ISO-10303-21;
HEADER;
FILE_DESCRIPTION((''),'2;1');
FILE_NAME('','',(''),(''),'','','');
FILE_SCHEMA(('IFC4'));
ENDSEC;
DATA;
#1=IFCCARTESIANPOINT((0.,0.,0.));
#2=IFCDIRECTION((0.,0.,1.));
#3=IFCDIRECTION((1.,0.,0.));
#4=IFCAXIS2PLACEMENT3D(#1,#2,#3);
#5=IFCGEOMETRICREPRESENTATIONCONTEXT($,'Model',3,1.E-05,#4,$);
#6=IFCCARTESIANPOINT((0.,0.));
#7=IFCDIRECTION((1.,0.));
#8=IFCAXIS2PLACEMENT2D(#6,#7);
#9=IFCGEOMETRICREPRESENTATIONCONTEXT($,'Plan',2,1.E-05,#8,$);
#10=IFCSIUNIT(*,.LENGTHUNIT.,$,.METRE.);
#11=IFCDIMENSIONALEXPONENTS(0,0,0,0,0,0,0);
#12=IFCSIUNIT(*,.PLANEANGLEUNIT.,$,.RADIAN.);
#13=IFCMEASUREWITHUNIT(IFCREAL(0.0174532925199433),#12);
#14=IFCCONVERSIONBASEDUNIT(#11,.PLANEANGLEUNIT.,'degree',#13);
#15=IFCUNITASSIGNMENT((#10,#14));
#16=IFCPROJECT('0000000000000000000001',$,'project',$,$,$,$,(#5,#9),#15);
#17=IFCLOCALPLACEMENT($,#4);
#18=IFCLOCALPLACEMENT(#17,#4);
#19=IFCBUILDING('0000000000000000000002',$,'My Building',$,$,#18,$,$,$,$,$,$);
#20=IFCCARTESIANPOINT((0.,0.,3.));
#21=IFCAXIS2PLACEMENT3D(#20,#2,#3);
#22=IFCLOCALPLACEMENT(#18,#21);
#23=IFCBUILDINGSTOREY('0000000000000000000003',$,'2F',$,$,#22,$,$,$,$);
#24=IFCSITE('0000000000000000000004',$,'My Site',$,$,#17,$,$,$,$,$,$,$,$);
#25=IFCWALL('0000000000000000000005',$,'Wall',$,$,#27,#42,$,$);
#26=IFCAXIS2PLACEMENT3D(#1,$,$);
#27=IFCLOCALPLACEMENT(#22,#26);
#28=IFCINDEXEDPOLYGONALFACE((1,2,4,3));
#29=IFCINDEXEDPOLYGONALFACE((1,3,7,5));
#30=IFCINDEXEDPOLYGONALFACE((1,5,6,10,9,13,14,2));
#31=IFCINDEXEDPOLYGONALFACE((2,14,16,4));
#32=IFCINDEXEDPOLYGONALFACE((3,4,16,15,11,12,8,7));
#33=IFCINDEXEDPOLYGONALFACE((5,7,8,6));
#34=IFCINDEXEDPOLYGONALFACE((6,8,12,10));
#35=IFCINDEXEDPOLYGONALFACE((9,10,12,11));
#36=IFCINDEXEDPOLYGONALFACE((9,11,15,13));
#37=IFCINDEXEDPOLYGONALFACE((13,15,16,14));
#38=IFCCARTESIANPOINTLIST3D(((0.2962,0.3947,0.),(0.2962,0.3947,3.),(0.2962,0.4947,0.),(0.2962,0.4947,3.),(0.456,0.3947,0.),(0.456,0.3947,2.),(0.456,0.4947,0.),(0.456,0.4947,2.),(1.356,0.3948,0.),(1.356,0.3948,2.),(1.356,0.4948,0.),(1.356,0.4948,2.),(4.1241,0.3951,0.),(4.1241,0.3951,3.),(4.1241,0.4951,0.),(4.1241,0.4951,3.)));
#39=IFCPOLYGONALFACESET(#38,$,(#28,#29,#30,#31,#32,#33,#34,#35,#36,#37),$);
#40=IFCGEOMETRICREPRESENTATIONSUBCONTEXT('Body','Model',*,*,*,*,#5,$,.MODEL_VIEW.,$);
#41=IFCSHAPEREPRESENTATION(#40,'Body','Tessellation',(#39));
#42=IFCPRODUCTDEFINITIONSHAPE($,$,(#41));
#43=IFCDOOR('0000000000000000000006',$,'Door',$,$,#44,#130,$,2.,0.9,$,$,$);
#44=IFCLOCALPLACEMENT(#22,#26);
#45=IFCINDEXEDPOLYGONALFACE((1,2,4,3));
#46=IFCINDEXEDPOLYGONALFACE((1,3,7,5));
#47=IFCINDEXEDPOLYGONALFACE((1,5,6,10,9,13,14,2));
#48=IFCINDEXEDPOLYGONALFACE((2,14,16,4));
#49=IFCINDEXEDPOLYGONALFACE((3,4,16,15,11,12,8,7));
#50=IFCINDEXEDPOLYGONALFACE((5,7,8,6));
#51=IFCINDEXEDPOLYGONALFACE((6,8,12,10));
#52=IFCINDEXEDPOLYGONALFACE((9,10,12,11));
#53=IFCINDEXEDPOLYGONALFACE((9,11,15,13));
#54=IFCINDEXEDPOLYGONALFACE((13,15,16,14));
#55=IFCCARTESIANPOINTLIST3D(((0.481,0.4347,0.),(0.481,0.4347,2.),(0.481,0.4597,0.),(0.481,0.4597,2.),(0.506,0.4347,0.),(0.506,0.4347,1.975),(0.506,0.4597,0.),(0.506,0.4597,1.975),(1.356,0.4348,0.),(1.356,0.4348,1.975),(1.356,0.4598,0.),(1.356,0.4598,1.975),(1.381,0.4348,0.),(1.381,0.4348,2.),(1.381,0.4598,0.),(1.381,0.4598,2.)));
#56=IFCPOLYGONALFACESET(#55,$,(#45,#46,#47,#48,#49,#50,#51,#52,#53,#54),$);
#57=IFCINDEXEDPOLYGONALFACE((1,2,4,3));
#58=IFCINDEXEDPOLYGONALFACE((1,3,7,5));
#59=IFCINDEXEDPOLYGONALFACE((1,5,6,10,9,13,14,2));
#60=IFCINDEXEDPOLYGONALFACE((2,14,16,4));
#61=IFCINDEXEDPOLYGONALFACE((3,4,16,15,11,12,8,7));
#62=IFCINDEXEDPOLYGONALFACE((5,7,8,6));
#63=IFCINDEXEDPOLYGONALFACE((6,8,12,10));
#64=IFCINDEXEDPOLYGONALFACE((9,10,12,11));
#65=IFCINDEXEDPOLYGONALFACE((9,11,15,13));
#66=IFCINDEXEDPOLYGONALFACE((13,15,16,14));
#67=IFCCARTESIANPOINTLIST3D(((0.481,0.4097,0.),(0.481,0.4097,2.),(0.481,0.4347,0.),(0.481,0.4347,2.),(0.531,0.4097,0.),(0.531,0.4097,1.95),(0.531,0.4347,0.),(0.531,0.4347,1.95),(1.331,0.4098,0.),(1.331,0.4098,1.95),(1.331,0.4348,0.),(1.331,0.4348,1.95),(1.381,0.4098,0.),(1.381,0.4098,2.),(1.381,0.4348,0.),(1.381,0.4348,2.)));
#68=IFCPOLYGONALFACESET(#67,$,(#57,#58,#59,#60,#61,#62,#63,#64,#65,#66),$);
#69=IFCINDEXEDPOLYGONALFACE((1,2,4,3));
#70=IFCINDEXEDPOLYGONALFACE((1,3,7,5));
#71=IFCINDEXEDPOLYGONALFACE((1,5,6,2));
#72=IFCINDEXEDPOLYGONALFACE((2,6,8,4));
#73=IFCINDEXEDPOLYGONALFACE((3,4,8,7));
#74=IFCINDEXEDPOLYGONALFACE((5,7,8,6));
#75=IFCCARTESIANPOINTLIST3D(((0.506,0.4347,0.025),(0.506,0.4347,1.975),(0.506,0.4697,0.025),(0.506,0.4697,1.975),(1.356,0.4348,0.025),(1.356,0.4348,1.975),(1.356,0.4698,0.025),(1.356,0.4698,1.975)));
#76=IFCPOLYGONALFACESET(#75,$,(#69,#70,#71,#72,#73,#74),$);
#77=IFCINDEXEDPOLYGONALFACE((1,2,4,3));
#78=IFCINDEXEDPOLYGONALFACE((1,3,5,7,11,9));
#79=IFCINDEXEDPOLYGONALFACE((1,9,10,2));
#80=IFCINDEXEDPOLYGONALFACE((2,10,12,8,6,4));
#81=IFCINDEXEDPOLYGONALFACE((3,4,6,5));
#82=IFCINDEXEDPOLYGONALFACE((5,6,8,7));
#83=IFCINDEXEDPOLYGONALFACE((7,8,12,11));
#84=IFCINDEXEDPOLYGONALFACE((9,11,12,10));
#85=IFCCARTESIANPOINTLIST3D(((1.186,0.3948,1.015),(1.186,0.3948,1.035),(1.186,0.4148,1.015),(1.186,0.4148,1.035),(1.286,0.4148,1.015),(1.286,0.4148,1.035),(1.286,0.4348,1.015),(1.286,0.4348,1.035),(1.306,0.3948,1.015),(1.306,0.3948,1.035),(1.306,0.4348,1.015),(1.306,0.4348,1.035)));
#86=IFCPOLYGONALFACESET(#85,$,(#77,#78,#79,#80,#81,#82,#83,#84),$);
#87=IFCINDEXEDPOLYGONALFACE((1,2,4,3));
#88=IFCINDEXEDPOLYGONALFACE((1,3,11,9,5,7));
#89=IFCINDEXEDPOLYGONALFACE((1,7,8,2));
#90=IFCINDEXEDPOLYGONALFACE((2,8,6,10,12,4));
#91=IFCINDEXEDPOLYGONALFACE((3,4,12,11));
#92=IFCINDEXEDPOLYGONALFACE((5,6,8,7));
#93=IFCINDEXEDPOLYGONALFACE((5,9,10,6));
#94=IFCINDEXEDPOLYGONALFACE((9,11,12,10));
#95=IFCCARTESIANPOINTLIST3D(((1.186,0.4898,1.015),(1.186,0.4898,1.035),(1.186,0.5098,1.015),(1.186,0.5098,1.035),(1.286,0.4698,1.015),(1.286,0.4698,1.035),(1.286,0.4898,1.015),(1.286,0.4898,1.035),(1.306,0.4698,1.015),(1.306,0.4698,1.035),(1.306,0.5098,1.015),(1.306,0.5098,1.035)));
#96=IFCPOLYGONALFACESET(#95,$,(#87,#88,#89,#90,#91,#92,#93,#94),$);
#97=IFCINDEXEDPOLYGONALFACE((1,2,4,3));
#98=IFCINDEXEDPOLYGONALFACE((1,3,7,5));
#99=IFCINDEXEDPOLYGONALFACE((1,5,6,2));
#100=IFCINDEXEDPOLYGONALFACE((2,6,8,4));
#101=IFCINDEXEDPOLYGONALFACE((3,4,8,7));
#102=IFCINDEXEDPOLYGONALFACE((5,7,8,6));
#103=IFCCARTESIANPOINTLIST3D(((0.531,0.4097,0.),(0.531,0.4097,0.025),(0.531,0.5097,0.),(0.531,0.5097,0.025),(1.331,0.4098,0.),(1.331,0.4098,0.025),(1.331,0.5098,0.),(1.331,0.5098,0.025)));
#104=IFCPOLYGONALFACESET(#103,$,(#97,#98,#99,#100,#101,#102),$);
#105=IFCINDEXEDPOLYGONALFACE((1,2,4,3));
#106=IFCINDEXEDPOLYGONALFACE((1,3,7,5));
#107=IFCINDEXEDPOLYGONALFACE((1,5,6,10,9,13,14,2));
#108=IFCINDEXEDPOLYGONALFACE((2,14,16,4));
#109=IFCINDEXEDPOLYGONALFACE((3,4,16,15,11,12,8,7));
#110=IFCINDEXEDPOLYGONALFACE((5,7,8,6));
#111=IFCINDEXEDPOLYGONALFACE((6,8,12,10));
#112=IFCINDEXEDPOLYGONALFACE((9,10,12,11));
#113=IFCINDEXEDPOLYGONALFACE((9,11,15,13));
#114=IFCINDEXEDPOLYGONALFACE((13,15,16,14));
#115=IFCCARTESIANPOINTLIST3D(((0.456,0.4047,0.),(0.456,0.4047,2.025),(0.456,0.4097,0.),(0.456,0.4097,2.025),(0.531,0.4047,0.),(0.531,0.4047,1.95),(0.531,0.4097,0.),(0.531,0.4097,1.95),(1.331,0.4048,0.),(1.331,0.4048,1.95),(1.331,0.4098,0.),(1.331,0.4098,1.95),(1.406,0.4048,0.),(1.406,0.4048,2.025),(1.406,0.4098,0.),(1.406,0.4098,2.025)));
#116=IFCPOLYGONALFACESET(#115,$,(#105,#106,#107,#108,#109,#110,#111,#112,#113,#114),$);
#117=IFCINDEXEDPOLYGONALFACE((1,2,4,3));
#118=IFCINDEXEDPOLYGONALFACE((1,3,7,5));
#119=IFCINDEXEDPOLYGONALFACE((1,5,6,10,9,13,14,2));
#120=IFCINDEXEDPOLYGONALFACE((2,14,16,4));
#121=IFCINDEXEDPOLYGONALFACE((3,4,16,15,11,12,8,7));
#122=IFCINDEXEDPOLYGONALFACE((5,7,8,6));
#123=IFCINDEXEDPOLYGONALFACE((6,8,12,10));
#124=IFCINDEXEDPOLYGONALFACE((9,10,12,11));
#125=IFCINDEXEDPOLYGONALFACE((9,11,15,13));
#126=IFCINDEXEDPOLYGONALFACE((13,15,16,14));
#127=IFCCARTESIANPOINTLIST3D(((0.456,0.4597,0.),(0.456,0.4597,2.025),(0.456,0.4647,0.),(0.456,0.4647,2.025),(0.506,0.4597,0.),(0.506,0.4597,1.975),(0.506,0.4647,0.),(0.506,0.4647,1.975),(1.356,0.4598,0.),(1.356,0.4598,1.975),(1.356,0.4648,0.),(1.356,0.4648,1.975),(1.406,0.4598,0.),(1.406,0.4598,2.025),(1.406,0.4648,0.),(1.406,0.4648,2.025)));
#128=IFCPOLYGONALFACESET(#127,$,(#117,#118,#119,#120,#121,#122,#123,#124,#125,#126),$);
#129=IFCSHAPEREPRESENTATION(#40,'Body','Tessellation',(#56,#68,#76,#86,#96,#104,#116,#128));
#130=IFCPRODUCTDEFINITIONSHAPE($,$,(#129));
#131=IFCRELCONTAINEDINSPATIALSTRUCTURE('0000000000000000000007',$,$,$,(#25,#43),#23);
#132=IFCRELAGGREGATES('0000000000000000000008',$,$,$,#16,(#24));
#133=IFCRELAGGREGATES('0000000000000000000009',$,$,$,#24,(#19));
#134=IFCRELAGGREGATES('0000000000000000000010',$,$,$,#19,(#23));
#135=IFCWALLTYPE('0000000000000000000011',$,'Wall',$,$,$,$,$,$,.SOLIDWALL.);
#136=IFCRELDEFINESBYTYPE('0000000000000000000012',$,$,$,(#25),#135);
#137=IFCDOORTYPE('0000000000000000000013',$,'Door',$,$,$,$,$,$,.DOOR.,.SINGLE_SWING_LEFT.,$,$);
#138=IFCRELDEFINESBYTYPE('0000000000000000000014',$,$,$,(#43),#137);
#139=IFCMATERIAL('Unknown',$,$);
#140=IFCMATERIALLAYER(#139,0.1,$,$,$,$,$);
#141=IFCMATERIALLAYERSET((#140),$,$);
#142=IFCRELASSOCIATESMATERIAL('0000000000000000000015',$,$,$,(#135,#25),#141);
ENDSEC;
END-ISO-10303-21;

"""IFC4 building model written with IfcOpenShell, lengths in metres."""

from ifc_helpers import new_model, entity, si_unit, converted_unit, frame, origin_with_axes, origin_2d_with_axis, place, context, subcontext, project, spatial, line, indexed_curve, outline, extrude, shape, source, transform, mapped, material, layer, layer_set, layer_usage, type_object, type_shapes, element, fill, save


model = new_model("IFC4")

# Units and contexts
model_context = context("Model", 3, precision=1e-05, world=origin_with_axes())
plan_context = context("Plan", 2, precision=1e-05, world=origin_2d_with_axis())
body_context_1 = subcontext(model_context, "Body", "Model", "MODEL_VIEW")
body_context_2 = subcontext(plan_context, "Body", "Plan", "PLAN_VIEW")
ifc_project = project(units=[si_unit("LENGTHUNIT", "METRE"), converted_unit("PLANEANGLEUNIT", "degree", entity("IfcReal", 0.0174532925199433), si_unit("PLANEANGLEUNIT", "RADIAN"), dimensions=[0, 0, 0, 0, 0, 0, 0])], contexts=[model_context, plan_context])

# Site, building, storey
site_placement = place(None, origin_with_axes())
site = spatial("IfcSite", under=ifc_project, at=site_placement, Name="My Site")
building_placement = place(site_placement, origin_with_axes())
building = spatial("IfcBuilding", under=site, at=building_placement, Name="My Building")
storey_placement = place(building_placement, frame((0.0, 0.0, 3.0), z_axis=(0.0, 0.0, 1.0), x_axis=(1.0, 0.0, 0.0)))
storey = spatial("IfcBuildingStorey", under=building, at=storey_placement, Name="2F")

# Shared definitions
ifc_material = material(Name="Unknown")

# Shared definitions
ifc_layer_1 = layer(ifc_material, 0.1)
ifc_layer_set_1 = layer_set([ifc_layer_1])
wall_type = type_object("IfcWallType", Name="Wall", PredefinedType="SOLIDWALL", material=ifc_layer_set_1)

# Wall, opening, door
ifc_layer_usage_1 = layer_usage(ifc_layer_set_1, "AXIS2", "POSITIVE", 0.0)
wall_1_placement = place(storey_placement, frame((4.1241, 0.4951, 0.0), z_axis=(0.0, 0.0, 1.0), x_axis=(-1.0, -0.000094, 0.0)))
wall_1 = element("IfcWall", 1, at=wall_1_placement, inside=storey, type_object=wall_type, material=ifc_layer_usage_1, Name="Wall", context=body_context_1, shape_type="SweptSolid", body=[
    extrude(outline(indexed_curve([(0.0, 0.0), (0.0, 0.1), (3.8279, 0.1), (3.8279, 0.0)], segments=[line(1, 2, 3, 4, 1)])), origin_with_axes(), (0.0, 0.0, 1.0), 3.0),
])
shared_shape_1 = source(origin_with_axes(), body_context_1, "Body", "SweptSolid", [
    extrude(outline(indexed_curve([(0.0, 0.0), (0.9, 0.0), (0.9, 2.0), (0.0, 2.0)], segments=[line(1, 2, 3, 4, 1)])), frame((0.0, -0.6, 0.0), z_axis=(0.0, -1.0, 0.0), x_axis=(1.0, 0.0, 0.0)), (0.0, 0.0, -1.0), 1.2),
])
opening_1_placement = place(wall_1_placement, frame((2.7681, 0.0, 0.0), z_axis=(0.0, 0.0, 1.0), x_axis=(1.0, 0.0, 0.0)))
opening_1 = element("IfcOpeningElement", 2, at=opening_1_placement, cuts=wall_1, PredefinedType="OPENING", context=body_context_1, shape_type="MappedRepresentation", body=[
    mapped(shared_shape_1, transform((0.0, 0.0, 0.0), x_axis=(1.0, 0.0, 0.0), y_axis=(0.0, 1.0, 0.0), z_axis=(0.0, 0.0, 1.0), scale=1.0)),
])
door_type_1 = type_object("IfcDoorType", Name="Door", OperationType="SINGLE_SWING_LEFT", PredefinedType="DOOR")
shared_shape_2 = source(origin_with_axes(), body_context_1, "Body", "SweptSolid", [
    extrude(outline(indexed_curve([(0.0, 0.0), (0.0, 2.0), (0.9, 2.0), (0.9, 0.0), (0.875, 0.0), (0.875, 1.975), (0.025, 1.975), (0.025, 0.0)], segments=[line(1, 2, 3, 4, 5, 6, 7, 8, 1)])), frame((0.0, 0.025, 0.0), z_axis=(0.0, -1.0, 0.0), x_axis=(1.0, 0.0, 0.0)), (0.0, 0.0, -1.0), 0.025),
    extrude(outline(indexed_curve([(0.0, 0.0), (0.0, 2.0), (0.9, 2.0), (0.9, 0.0), (0.85, 0.0), (0.85, 1.95), (0.05, 1.95), (0.05, 0.0)], segments=[line(1, 2, 3, 4, 5, 6, 7, 8, 1)])), frame((0.0, 0.0, 0.0), z_axis=(0.0, -1.0, 0.0), x_axis=(1.0, 0.0, 0.0)), (0.0, 0.0, -1.0), 0.025),
    extrude(outline(indexed_curve([(0.0, 0.0), (0.85, 0.0), (0.85, 0.035), (0.0, 0.035)], segments=[line(1, 2, 3, 4, 1)])), frame((0.025, 0.025, 0.025), z_axis=(0.0, 0.0, 1.0), x_axis=(1.0, 0.0, 0.0)), (0.0, 0.0, 1.0), 1.95),
    extrude(outline(indexed_curve([(0.0, 0.0), (0.0, -0.04), (-0.12, -0.04), (-0.12, -0.02), (-0.02, -0.02), (-0.02, 0.0)], segments=[line(1, 2, 3, 4, 5, 6, 1)])), frame((0.825, 0.025, 1.015), z_axis=(0.0, 0.0, 1.0), x_axis=(1.0, 0.0, 0.0)), (0.0, 0.0, 1.0), 0.02),
    extrude(outline(indexed_curve([(0.0, 0.0), (0.0, 0.04), (-0.12, 0.04), (-0.12, 0.02), (-0.02, 0.02), (-0.02, 0.0)], segments=[line(1, 2, 3, 4, 5, 6, 1)])), frame((0.825, 0.06, 1.015), z_axis=(0.0, 0.0, 1.0), x_axis=(1.0, 0.0, 0.0)), (0.0, 0.0, 1.0), 0.02),
    extrude(outline(indexed_curve([(0.0, 0.0), (0.8, 0.0), (0.8, 0.1), (0.0, 0.1)], segments=[line(1, 2, 3, 4, 1)])), frame((0.05, 0.0, 0.0), z_axis=(0.0, 0.0, 1.0), x_axis=(1.0, 0.0, 0.0)), (0.0, 0.0, 1.0), 0.025),
    extrude(outline(indexed_curve([(0.0, 0.0), (0.0, 2.025), (0.95, 2.025), (0.95, 0.0), (0.875, 0.0), (0.875, 1.95), (0.075, 1.95), (0.075, 0.0)], segments=[line(1, 2, 3, 4, 5, 6, 7, 8, 1)])), frame((-0.025, -0.005, 0.0), z_axis=(0.0, -1.0, 0.0), x_axis=(1.0, 0.0, 0.0)), (0.0, 0.0, -1.0), 0.005),
    extrude(outline(indexed_curve([(0.0, 0.0), (0.0, 2.025), (0.95, 2.025), (0.95, 0.0), (0.9, 0.0), (0.9, 1.975), (0.05, 1.975), (0.05, 0.0)], segments=[line(1, 2, 3, 4, 5, 6, 7, 8, 1)])), frame((-0.025, 0.05, 0.0), z_axis=(0.0, -1.0, 0.0), x_axis=(1.0, 0.0, 0.0)), (0.0, 0.0, -1.0), 0.005),
])
shared_shape_3 = source(origin_with_axes(), body_context_2, "Body", "Curve2D", [
    entity("IfcIndexedPolyCurve", entity("IfcCartesianPointList2D", [[0.0, 0.0], [0.0, 0.05], [0.025, 0.05], [0.025, 0.025], [0.05, 0.025], [0.05, 0.0]]), [entity("IfcLineIndex", [1, 2, 3, 4, 5, 6, 1])]),
    entity("IfcIndexedPolyCurve", entity("IfcCartesianPointList2D", [[0.9, 0.0], [0.9, 0.05], [0.875, 0.05], [0.875, 0.025], [0.85, 0.025], [0.85, 0.0]]), [entity("IfcLineIndex", [1, 2, 3, 4, 5, 6, 1])]),
    entity("IfcTrimmedCurve", entity("IfcEllipse", entity("IfcAxis2Placement2D", entity("IfcCartesianPoint", [0.06, 0.05]), entity("IfcDirection", [1.0, 0.0])), 0.815, 0.85), [entity("IfcCartesianPoint", [0.875, 0.05])], [entity("IfcCartesianPoint", [0.06, 0.9])], True, "CARTESIAN"),
    entity("IfcIndexedPolyCurve", entity("IfcCartesianPointList2D", [[0.025, 0.05], [0.06, 0.05], [0.06, 0.9], [0.025, 0.9]]), [entity("IfcLineIndex", [1, 2, 3, 4, 1])]),
])
type_shapes(door_type_1, [shared_shape_2, shared_shape_3])
door_1_placement = place(opening_1_placement, frame((0.875, 0.085, 0.0), z_axis=(0.0, 0.0, 1.0), x_axis=(-1.0, 0.0, 0.0)))
door_1 = element("IfcDoor", 3, at=door_1_placement, inside=storey, type_object=door_type_1, Name="Door", OverallHeight=2.0, OverallWidth=0.9, shapes=[
    shape(body_context_1, "Body", "MappedRepresentation", [mapped(shared_shape_2, transform((0.0, 0.0, 0.0), x_axis=(1.0, 0.0, 0.0), y_axis=(0.0, 1.0, 0.0), z_axis=(0.0, 0.0, 1.0), scale=1.0))]),
    shape(body_context_2, "Body", "MappedRepresentation", [mapped(shared_shape_3, transform((0.0, 0.0, 0.0), x_axis=(1.0, 0.0, 0.0), y_axis=(0.0, 1.0, 0.0), z_axis=(0.0, 0.0, 1.0), scale=1.0))]),
])
fill(opening_1, door_1)

save(model, "model.ifc")
